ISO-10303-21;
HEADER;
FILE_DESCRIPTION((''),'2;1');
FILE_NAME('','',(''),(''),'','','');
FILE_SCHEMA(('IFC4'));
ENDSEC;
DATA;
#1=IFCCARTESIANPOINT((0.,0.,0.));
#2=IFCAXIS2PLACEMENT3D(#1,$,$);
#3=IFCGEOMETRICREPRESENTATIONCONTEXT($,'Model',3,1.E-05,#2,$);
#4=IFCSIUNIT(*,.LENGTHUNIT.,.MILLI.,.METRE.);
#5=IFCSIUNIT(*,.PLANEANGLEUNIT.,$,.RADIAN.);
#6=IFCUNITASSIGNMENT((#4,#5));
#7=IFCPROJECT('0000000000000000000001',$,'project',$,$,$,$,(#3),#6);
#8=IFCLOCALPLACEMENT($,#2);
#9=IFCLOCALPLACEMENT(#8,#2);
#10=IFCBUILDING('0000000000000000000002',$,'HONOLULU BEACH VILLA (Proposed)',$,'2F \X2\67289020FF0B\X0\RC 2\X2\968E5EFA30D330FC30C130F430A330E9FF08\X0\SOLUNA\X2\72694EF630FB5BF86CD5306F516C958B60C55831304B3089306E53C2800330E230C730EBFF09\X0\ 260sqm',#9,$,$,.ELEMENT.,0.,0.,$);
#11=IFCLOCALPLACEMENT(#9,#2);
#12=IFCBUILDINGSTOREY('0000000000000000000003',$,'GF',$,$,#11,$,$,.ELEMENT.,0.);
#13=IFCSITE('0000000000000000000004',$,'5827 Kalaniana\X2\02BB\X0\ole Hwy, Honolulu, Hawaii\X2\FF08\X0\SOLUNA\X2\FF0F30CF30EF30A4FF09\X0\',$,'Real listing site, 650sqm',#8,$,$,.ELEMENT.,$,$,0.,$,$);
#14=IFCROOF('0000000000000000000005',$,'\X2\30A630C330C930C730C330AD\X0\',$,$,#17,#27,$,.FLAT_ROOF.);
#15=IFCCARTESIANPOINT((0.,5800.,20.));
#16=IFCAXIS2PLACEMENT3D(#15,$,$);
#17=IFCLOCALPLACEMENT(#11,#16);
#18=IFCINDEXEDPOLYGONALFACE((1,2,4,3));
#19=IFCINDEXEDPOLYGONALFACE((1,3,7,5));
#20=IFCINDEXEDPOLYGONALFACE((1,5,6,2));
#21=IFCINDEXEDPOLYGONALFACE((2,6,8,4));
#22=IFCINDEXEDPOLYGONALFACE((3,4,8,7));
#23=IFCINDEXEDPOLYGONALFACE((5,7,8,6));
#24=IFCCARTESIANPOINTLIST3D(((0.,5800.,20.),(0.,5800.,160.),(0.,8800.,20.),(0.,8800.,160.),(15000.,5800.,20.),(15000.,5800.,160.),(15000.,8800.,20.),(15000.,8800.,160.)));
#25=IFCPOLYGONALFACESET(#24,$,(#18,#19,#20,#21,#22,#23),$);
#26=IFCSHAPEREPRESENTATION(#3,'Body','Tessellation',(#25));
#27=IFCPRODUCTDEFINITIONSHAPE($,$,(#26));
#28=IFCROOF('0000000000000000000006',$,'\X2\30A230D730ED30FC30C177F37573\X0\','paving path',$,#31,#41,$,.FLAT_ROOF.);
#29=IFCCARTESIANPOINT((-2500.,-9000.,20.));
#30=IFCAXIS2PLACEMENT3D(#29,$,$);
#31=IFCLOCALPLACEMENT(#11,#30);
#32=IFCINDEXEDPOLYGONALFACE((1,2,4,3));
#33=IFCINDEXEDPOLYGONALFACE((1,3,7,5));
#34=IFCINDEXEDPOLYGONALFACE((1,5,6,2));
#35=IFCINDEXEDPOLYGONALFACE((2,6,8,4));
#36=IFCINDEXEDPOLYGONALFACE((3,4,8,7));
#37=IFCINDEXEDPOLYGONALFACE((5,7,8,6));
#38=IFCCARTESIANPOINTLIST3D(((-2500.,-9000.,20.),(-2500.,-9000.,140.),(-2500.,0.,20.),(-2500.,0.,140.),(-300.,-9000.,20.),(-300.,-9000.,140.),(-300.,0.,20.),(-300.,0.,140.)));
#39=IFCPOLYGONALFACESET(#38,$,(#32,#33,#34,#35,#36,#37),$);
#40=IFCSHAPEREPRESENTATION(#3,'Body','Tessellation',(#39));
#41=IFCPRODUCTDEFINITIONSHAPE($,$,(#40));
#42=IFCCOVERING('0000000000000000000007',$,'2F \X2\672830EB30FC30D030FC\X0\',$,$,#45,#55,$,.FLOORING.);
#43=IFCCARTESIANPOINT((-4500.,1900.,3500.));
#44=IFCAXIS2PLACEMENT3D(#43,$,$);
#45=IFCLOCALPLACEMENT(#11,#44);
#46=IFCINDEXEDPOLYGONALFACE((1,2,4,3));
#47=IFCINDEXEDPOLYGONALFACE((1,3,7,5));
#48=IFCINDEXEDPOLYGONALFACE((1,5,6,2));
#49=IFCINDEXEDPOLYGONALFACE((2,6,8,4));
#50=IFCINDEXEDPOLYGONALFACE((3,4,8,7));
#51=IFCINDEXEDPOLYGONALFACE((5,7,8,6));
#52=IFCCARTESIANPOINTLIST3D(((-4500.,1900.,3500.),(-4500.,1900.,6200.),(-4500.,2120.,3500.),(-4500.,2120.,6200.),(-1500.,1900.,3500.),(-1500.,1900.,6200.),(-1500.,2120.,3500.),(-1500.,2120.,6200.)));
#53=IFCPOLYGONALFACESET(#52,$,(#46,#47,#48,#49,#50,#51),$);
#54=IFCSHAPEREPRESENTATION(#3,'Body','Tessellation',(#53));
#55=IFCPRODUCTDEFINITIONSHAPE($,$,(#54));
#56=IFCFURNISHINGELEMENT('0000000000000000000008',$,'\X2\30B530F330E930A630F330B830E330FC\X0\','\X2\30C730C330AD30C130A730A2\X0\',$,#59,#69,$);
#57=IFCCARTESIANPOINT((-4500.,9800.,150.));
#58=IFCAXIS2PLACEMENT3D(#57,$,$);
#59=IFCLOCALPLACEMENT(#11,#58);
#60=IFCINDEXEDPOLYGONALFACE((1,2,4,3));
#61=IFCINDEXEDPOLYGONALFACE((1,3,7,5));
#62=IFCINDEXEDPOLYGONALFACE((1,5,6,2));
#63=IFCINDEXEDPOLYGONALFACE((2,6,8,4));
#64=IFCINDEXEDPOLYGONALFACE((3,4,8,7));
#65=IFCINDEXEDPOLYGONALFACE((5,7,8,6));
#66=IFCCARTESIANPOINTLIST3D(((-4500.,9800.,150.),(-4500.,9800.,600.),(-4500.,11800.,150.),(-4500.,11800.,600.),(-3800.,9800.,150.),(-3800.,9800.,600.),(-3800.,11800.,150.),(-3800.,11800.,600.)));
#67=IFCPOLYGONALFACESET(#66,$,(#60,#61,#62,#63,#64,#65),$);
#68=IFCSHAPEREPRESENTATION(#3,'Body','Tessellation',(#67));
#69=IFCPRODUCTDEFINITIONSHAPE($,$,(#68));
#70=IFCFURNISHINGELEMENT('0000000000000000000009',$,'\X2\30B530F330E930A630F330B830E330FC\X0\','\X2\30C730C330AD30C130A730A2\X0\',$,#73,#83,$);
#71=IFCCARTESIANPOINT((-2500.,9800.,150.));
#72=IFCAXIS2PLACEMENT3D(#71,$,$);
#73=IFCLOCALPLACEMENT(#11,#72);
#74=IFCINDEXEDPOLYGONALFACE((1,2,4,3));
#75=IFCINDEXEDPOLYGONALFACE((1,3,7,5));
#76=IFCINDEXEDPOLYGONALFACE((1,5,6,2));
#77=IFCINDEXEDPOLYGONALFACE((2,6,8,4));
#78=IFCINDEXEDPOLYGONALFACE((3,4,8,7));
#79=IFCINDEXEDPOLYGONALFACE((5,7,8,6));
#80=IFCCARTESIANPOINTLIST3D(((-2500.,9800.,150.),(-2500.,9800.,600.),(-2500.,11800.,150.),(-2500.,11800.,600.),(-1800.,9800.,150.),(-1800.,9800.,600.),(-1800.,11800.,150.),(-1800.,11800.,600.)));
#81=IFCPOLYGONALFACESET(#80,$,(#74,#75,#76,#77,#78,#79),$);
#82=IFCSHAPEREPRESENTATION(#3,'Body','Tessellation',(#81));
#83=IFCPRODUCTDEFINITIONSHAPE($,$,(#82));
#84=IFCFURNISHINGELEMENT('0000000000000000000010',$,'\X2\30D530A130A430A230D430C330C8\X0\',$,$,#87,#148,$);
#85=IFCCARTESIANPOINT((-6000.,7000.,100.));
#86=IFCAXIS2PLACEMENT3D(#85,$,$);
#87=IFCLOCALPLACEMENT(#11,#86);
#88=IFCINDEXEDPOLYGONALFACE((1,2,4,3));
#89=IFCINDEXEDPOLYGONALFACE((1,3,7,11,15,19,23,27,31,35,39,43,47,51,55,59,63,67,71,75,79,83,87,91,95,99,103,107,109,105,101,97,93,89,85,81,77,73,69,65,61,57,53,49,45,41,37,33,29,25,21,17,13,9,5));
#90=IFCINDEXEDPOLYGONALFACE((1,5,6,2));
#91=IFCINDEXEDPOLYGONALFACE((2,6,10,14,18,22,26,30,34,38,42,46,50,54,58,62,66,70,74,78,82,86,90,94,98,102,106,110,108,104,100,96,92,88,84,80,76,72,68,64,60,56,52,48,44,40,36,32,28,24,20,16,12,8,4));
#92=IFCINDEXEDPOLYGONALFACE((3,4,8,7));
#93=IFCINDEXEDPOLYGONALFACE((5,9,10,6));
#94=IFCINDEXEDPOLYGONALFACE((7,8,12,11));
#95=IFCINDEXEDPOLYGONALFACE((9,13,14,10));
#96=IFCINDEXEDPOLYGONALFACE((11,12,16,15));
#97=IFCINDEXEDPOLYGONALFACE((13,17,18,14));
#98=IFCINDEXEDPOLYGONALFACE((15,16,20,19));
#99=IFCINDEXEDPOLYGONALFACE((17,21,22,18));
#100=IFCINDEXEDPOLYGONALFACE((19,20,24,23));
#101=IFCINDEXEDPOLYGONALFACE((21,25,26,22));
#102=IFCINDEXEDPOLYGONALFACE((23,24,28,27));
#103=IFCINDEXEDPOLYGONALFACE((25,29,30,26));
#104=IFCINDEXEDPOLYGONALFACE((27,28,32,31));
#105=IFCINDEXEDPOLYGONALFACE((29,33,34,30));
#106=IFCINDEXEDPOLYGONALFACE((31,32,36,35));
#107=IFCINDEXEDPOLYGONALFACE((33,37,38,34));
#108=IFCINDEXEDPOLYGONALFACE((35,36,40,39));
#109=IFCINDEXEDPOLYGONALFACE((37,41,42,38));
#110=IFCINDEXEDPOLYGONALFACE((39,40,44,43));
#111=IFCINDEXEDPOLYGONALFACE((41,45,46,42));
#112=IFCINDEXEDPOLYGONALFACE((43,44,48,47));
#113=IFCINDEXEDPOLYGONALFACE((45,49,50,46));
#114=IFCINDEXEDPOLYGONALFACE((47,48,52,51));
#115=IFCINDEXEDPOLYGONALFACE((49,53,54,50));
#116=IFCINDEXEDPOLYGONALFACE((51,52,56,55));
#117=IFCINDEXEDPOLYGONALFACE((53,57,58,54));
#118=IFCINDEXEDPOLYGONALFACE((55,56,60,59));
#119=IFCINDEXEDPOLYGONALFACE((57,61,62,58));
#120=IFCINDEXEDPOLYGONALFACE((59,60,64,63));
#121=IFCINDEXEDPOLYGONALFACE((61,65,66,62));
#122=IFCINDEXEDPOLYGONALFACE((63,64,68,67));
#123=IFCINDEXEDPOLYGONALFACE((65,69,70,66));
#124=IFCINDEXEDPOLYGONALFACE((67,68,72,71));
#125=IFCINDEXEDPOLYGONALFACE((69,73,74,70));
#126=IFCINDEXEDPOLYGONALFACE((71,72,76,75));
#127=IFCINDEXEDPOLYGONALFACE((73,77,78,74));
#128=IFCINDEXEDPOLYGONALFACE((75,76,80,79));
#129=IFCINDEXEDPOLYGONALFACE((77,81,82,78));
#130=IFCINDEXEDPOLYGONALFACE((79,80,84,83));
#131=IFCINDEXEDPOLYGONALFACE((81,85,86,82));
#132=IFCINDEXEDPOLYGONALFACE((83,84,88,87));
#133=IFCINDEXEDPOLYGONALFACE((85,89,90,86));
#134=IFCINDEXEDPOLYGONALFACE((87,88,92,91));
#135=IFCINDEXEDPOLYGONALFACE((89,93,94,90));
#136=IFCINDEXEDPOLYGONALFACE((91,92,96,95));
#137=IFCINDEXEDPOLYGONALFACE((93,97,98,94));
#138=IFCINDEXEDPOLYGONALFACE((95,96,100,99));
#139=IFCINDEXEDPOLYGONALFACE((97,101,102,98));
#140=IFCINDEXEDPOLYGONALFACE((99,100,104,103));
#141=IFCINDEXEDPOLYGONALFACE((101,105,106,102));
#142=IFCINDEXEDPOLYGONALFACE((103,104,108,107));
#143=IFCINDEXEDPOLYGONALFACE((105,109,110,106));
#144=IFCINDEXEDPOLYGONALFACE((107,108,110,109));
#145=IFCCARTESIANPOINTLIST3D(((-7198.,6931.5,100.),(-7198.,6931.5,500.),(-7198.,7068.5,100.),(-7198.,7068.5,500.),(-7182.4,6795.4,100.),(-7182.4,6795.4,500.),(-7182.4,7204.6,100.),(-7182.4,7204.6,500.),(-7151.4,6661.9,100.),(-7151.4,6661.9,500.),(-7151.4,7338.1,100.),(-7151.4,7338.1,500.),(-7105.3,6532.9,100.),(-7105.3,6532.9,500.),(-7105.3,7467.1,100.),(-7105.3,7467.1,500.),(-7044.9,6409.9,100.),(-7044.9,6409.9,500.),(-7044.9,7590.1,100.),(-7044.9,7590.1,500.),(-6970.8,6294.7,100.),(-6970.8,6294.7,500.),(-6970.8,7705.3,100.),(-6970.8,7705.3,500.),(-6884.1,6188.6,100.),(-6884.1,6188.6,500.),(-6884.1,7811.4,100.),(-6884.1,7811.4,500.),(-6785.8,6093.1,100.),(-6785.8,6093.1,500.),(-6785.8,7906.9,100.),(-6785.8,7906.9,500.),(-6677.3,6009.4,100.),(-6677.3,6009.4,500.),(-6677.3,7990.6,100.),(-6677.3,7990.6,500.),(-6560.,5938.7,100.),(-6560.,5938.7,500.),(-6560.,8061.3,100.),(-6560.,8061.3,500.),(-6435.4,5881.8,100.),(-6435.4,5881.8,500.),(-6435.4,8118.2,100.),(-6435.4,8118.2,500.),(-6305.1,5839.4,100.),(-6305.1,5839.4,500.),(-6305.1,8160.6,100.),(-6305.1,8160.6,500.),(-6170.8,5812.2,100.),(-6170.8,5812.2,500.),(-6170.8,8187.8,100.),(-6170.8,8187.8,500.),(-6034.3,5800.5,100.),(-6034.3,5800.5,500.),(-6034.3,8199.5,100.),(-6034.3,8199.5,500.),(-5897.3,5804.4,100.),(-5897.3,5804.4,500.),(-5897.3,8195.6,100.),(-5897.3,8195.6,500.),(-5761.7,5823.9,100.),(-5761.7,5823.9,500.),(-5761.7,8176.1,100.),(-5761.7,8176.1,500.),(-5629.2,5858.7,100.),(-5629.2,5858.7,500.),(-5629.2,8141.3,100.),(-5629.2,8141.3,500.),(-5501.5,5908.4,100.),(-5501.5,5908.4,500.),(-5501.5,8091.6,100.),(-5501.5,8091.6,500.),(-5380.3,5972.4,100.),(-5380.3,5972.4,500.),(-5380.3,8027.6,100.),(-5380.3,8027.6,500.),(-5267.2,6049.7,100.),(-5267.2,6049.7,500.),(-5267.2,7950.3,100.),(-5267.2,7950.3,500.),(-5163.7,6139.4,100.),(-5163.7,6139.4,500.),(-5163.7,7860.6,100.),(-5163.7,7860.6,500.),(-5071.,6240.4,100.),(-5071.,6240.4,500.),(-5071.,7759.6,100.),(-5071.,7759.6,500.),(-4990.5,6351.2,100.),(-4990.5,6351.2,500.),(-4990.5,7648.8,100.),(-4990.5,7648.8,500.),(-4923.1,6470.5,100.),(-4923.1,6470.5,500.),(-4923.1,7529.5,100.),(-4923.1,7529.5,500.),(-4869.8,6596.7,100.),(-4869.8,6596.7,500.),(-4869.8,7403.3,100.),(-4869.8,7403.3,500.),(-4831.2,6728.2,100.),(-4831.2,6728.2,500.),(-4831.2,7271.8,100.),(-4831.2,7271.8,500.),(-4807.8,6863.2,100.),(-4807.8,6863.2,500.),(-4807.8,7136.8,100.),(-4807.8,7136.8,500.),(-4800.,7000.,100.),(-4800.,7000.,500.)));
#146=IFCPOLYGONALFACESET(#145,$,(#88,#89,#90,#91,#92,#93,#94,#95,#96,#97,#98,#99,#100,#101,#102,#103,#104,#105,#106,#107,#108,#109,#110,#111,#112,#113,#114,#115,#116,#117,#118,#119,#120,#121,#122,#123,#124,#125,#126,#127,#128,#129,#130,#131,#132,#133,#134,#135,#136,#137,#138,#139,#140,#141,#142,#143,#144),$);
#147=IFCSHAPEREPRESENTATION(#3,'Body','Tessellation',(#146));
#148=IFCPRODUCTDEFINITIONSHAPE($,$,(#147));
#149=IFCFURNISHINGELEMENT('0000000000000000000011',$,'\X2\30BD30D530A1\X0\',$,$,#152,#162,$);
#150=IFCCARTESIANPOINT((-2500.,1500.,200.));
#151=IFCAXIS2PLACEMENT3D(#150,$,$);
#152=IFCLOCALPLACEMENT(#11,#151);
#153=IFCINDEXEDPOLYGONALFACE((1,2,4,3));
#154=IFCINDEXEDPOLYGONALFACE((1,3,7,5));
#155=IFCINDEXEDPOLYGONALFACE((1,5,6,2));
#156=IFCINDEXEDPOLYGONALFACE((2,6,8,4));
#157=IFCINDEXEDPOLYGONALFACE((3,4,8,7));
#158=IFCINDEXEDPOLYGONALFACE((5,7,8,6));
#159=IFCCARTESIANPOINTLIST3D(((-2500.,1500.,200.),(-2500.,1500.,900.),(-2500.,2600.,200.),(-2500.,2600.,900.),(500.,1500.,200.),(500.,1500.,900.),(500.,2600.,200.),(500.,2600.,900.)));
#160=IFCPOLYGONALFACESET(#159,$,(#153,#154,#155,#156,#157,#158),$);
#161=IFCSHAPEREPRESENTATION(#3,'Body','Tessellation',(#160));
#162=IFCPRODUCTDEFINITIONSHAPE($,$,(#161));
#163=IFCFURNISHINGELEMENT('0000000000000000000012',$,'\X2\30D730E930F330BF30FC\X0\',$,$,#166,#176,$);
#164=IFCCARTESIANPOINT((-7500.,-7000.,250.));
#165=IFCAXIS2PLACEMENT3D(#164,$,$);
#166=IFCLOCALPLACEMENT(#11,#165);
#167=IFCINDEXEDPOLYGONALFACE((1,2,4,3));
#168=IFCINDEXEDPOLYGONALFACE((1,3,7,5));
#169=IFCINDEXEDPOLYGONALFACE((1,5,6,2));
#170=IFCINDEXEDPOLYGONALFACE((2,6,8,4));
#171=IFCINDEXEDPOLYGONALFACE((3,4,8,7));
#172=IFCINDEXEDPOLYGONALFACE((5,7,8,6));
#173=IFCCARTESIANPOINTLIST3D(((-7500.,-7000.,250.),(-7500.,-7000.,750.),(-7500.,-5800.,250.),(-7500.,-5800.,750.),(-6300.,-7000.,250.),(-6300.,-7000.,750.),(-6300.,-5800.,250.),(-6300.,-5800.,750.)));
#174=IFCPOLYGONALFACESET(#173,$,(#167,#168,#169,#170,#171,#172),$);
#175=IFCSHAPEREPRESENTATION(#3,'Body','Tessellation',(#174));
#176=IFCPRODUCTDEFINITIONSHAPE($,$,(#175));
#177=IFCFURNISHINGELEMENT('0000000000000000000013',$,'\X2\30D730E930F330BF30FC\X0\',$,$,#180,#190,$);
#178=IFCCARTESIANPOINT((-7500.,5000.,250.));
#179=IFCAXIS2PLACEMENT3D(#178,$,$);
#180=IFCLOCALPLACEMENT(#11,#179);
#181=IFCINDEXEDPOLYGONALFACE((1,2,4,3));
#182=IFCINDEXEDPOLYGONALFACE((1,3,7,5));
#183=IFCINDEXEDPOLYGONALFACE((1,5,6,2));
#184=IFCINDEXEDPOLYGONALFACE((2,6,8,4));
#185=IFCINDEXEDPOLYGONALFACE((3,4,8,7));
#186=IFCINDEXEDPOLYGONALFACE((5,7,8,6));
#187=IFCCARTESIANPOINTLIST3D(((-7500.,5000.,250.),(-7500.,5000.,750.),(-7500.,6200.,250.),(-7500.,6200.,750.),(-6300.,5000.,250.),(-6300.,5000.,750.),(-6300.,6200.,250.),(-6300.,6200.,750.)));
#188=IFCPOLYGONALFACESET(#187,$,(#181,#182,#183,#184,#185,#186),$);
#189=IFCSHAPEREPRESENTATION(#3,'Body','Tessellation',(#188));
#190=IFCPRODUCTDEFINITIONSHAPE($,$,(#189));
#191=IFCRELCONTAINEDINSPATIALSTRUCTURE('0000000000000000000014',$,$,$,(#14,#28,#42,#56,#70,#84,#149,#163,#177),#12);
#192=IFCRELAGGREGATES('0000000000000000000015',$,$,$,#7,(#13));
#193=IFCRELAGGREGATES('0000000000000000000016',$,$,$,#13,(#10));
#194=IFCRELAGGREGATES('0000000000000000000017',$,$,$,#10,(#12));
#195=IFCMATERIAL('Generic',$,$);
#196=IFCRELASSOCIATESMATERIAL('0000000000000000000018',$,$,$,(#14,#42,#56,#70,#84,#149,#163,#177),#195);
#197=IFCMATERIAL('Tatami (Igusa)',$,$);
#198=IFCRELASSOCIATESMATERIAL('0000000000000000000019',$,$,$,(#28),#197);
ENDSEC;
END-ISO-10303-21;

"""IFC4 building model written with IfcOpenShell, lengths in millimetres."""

from ifc_helpers import new_model, si_unit, frame, frame_2d, origin, origin_2d, place, context, project, spatial, rectangle, circle, extrude, material, element, save


model = new_model("IFC4")

# Units and contexts
model_context = context("Model", 3, precision=1e-05, world=origin())
ifc_project = project(units=[si_unit("LENGTHUNIT", "METRE", prefix="MILLI"), si_unit("PLANEANGLEUNIT", "RADIAN")], contexts=[model_context])

# Site, building, storey
site_placement = place(None, origin())
site = spatial("IfcSite", under=ifc_project, at=site_placement, Name="5827 Kalanianaʻole Hwy, Honolulu, Hawaii（SOLUNA／ハワイ）", ObjectType="Real listing site, 650sqm", CompositionType="ELEMENT", RefElevation=0.0)
building_placement = place(site_placement, origin())
building = spatial("IfcBuilding", under=site, at=building_placement, Name="HONOLULU BEACH VILLA (Proposed)", ObjectType="2F 木造＋RC 2階建ビーチヴィラ（SOLUNA物件・寸法は公開情報からの参考モデル） 260sqm", CompositionType="ELEMENT", ElevationOfRefHeight=0.0, ElevationOfTerrain=0.0)
storey_placement = place(building_placement, origin())
storey = spatial("IfcBuildingStorey", under=building, at=storey_placement, Name="GF", CompositionType="ELEMENT", Elevation=0.0)

# Shared definitions
ifc_material_1 = material(Name="Generic")

# Roofs
roof_1_placement = place(storey_placement, frame((0.0, 5800.0, 20.0)))
element("IfcRoof", 1, at=roof_1_placement, inside=storey, material=ifc_material_1, Name="ウッドデッキ", PredefinedType="FLAT_ROOF", context=model_context, shape_type="SweptSolid", body=[
    extrude(rectangle(XDim=15000.0, YDim=3000.0, at=frame_2d((7500.0, 1500.0))), frame((0.0, 5800.0, 20.0)), (0.0, 0.0, 1.0), 140.0),
])
ifc_material_2 = material(Name="Tatami (Igusa)")
roof_2_placement = place(storey_placement, frame((-2500.0, -9000.0, 20.0)))
element("IfcRoof", 2, at=roof_2_placement, inside=storey, material=ifc_material_2, Name="アプローチ石畳", Description="paving path", PredefinedType="FLAT_ROOF", context=model_context, shape_type="SweptSolid", body=[
    extrude(rectangle(XDim=2200.0, YDim=9000.0, at=frame_2d((1100.0, 4500.0))), frame((-2500.0, -9000.0, 20.0)), (0.0, 0.0, 1.0), 120.0),
])

# Covering
covering_placement = place(storey_placement, frame((-4500.0, 1900.0, 3500.0)))
element("IfcCovering", 3, at=covering_placement, inside=storey, material=ifc_material_1, Name="2F 木ルーバー", PredefinedType="FLOORING", context=model_context, shape_type="SweptSolid", body=[
    extrude(rectangle(XDim=3000.0, YDim=220.0, at=frame_2d((1500.0, 110.0))), frame((-4500.0, 1900.0, 3500.0)), (0.0, 0.0, 1.0), 2700.0),
])

# Furnishing elements
furnishing_1_placement = place(storey_placement, frame((-4500.0, 9800.0, 150.0)))
element("IfcFurnishingElement", 4, at=furnishing_1_placement, inside=storey, material=ifc_material_1, Name="サンラウンジャー", Description="デッキチェア", context=model_context, shape_type="SweptSolid", body=[
    extrude(rectangle(XDim=700.0, YDim=2000.0, at=frame_2d((350.0, 1000.0))), frame((-4500.0, 9800.0, 150.0)), (0.0, 0.0, 1.0), 450.0),
])
furnishing_2_placement = place(storey_placement, frame((-2500.0, 9800.0, 150.0)))
element("IfcFurnishingElement", 5, at=furnishing_2_placement, inside=storey, material=ifc_material_1, Name="サンラウンジャー", Description="デッキチェア", context=model_context, shape_type="SweptSolid", body=[
    extrude(rectangle(XDim=700.0, YDim=2000.0, at=frame_2d((350.0, 1000.0))), frame((-2500.0, 9800.0, 150.0)), (0.0, 0.0, 1.0), 450.0),
])
furnishing_3_placement = place(storey_placement, frame((-6000.0, 7000.0, 100.0)))
element("IfcFurnishingElement", 6, at=furnishing_3_placement, inside=storey, material=ifc_material_1, Name="ファイアピット", context=model_context, shape_type="SweptSolid", body=[
    extrude(circle(Radius=1200.0, at=origin_2d()), frame((-6000.0, 7000.0, 100.0)), (0.0, 0.0, 1.0), 400.0),
])
furnishing_4_placement = place(storey_placement, frame((-2500.0, 1500.0, 200.0)))
element("IfcFurnishingElement", 7, at=furnishing_4_placement, inside=storey, material=ifc_material_1, Name="ソファ", context=model_context, shape_type="SweptSolid", body=[
    extrude(rectangle(XDim=3000.0, YDim=1100.0, at=frame_2d((1500.0, 550.0))), frame((-2500.0, 1500.0, 200.0)), (0.0, 0.0, 1.0), 700.0),
])
furnishing_5_placement = place(storey_placement, frame((-7500.0, -7000.0, 250.0)))
element("IfcFurnishingElement", 8, at=furnishing_5_placement, inside=storey, material=ifc_material_1, Name="プランター", context=model_context, shape_type="SweptSolid", body=[
    extrude(rectangle(XDim=1200.0, YDim=1200.0, at=frame_2d((600.0, 600.0))), frame((-7500.0, -7000.0, 250.0)), (0.0, 0.0, 1.0), 500.0),
])
furnishing_6_placement = place(storey_placement, frame((-7500.0, 5000.0, 250.0)))
element("IfcFurnishingElement", 9, at=furnishing_6_placement, inside=storey, material=ifc_material_1, Name="プランター", context=model_context, shape_type="SweptSolid", body=[
    extrude(rectangle(XDim=1200.0, YDim=1200.0, at=frame_2d((600.0, 600.0))), frame((-7500.0, 5000.0, 250.0)), (0.0, 0.0, 1.0), 500.0),
])

save(model, "model.ifc")
